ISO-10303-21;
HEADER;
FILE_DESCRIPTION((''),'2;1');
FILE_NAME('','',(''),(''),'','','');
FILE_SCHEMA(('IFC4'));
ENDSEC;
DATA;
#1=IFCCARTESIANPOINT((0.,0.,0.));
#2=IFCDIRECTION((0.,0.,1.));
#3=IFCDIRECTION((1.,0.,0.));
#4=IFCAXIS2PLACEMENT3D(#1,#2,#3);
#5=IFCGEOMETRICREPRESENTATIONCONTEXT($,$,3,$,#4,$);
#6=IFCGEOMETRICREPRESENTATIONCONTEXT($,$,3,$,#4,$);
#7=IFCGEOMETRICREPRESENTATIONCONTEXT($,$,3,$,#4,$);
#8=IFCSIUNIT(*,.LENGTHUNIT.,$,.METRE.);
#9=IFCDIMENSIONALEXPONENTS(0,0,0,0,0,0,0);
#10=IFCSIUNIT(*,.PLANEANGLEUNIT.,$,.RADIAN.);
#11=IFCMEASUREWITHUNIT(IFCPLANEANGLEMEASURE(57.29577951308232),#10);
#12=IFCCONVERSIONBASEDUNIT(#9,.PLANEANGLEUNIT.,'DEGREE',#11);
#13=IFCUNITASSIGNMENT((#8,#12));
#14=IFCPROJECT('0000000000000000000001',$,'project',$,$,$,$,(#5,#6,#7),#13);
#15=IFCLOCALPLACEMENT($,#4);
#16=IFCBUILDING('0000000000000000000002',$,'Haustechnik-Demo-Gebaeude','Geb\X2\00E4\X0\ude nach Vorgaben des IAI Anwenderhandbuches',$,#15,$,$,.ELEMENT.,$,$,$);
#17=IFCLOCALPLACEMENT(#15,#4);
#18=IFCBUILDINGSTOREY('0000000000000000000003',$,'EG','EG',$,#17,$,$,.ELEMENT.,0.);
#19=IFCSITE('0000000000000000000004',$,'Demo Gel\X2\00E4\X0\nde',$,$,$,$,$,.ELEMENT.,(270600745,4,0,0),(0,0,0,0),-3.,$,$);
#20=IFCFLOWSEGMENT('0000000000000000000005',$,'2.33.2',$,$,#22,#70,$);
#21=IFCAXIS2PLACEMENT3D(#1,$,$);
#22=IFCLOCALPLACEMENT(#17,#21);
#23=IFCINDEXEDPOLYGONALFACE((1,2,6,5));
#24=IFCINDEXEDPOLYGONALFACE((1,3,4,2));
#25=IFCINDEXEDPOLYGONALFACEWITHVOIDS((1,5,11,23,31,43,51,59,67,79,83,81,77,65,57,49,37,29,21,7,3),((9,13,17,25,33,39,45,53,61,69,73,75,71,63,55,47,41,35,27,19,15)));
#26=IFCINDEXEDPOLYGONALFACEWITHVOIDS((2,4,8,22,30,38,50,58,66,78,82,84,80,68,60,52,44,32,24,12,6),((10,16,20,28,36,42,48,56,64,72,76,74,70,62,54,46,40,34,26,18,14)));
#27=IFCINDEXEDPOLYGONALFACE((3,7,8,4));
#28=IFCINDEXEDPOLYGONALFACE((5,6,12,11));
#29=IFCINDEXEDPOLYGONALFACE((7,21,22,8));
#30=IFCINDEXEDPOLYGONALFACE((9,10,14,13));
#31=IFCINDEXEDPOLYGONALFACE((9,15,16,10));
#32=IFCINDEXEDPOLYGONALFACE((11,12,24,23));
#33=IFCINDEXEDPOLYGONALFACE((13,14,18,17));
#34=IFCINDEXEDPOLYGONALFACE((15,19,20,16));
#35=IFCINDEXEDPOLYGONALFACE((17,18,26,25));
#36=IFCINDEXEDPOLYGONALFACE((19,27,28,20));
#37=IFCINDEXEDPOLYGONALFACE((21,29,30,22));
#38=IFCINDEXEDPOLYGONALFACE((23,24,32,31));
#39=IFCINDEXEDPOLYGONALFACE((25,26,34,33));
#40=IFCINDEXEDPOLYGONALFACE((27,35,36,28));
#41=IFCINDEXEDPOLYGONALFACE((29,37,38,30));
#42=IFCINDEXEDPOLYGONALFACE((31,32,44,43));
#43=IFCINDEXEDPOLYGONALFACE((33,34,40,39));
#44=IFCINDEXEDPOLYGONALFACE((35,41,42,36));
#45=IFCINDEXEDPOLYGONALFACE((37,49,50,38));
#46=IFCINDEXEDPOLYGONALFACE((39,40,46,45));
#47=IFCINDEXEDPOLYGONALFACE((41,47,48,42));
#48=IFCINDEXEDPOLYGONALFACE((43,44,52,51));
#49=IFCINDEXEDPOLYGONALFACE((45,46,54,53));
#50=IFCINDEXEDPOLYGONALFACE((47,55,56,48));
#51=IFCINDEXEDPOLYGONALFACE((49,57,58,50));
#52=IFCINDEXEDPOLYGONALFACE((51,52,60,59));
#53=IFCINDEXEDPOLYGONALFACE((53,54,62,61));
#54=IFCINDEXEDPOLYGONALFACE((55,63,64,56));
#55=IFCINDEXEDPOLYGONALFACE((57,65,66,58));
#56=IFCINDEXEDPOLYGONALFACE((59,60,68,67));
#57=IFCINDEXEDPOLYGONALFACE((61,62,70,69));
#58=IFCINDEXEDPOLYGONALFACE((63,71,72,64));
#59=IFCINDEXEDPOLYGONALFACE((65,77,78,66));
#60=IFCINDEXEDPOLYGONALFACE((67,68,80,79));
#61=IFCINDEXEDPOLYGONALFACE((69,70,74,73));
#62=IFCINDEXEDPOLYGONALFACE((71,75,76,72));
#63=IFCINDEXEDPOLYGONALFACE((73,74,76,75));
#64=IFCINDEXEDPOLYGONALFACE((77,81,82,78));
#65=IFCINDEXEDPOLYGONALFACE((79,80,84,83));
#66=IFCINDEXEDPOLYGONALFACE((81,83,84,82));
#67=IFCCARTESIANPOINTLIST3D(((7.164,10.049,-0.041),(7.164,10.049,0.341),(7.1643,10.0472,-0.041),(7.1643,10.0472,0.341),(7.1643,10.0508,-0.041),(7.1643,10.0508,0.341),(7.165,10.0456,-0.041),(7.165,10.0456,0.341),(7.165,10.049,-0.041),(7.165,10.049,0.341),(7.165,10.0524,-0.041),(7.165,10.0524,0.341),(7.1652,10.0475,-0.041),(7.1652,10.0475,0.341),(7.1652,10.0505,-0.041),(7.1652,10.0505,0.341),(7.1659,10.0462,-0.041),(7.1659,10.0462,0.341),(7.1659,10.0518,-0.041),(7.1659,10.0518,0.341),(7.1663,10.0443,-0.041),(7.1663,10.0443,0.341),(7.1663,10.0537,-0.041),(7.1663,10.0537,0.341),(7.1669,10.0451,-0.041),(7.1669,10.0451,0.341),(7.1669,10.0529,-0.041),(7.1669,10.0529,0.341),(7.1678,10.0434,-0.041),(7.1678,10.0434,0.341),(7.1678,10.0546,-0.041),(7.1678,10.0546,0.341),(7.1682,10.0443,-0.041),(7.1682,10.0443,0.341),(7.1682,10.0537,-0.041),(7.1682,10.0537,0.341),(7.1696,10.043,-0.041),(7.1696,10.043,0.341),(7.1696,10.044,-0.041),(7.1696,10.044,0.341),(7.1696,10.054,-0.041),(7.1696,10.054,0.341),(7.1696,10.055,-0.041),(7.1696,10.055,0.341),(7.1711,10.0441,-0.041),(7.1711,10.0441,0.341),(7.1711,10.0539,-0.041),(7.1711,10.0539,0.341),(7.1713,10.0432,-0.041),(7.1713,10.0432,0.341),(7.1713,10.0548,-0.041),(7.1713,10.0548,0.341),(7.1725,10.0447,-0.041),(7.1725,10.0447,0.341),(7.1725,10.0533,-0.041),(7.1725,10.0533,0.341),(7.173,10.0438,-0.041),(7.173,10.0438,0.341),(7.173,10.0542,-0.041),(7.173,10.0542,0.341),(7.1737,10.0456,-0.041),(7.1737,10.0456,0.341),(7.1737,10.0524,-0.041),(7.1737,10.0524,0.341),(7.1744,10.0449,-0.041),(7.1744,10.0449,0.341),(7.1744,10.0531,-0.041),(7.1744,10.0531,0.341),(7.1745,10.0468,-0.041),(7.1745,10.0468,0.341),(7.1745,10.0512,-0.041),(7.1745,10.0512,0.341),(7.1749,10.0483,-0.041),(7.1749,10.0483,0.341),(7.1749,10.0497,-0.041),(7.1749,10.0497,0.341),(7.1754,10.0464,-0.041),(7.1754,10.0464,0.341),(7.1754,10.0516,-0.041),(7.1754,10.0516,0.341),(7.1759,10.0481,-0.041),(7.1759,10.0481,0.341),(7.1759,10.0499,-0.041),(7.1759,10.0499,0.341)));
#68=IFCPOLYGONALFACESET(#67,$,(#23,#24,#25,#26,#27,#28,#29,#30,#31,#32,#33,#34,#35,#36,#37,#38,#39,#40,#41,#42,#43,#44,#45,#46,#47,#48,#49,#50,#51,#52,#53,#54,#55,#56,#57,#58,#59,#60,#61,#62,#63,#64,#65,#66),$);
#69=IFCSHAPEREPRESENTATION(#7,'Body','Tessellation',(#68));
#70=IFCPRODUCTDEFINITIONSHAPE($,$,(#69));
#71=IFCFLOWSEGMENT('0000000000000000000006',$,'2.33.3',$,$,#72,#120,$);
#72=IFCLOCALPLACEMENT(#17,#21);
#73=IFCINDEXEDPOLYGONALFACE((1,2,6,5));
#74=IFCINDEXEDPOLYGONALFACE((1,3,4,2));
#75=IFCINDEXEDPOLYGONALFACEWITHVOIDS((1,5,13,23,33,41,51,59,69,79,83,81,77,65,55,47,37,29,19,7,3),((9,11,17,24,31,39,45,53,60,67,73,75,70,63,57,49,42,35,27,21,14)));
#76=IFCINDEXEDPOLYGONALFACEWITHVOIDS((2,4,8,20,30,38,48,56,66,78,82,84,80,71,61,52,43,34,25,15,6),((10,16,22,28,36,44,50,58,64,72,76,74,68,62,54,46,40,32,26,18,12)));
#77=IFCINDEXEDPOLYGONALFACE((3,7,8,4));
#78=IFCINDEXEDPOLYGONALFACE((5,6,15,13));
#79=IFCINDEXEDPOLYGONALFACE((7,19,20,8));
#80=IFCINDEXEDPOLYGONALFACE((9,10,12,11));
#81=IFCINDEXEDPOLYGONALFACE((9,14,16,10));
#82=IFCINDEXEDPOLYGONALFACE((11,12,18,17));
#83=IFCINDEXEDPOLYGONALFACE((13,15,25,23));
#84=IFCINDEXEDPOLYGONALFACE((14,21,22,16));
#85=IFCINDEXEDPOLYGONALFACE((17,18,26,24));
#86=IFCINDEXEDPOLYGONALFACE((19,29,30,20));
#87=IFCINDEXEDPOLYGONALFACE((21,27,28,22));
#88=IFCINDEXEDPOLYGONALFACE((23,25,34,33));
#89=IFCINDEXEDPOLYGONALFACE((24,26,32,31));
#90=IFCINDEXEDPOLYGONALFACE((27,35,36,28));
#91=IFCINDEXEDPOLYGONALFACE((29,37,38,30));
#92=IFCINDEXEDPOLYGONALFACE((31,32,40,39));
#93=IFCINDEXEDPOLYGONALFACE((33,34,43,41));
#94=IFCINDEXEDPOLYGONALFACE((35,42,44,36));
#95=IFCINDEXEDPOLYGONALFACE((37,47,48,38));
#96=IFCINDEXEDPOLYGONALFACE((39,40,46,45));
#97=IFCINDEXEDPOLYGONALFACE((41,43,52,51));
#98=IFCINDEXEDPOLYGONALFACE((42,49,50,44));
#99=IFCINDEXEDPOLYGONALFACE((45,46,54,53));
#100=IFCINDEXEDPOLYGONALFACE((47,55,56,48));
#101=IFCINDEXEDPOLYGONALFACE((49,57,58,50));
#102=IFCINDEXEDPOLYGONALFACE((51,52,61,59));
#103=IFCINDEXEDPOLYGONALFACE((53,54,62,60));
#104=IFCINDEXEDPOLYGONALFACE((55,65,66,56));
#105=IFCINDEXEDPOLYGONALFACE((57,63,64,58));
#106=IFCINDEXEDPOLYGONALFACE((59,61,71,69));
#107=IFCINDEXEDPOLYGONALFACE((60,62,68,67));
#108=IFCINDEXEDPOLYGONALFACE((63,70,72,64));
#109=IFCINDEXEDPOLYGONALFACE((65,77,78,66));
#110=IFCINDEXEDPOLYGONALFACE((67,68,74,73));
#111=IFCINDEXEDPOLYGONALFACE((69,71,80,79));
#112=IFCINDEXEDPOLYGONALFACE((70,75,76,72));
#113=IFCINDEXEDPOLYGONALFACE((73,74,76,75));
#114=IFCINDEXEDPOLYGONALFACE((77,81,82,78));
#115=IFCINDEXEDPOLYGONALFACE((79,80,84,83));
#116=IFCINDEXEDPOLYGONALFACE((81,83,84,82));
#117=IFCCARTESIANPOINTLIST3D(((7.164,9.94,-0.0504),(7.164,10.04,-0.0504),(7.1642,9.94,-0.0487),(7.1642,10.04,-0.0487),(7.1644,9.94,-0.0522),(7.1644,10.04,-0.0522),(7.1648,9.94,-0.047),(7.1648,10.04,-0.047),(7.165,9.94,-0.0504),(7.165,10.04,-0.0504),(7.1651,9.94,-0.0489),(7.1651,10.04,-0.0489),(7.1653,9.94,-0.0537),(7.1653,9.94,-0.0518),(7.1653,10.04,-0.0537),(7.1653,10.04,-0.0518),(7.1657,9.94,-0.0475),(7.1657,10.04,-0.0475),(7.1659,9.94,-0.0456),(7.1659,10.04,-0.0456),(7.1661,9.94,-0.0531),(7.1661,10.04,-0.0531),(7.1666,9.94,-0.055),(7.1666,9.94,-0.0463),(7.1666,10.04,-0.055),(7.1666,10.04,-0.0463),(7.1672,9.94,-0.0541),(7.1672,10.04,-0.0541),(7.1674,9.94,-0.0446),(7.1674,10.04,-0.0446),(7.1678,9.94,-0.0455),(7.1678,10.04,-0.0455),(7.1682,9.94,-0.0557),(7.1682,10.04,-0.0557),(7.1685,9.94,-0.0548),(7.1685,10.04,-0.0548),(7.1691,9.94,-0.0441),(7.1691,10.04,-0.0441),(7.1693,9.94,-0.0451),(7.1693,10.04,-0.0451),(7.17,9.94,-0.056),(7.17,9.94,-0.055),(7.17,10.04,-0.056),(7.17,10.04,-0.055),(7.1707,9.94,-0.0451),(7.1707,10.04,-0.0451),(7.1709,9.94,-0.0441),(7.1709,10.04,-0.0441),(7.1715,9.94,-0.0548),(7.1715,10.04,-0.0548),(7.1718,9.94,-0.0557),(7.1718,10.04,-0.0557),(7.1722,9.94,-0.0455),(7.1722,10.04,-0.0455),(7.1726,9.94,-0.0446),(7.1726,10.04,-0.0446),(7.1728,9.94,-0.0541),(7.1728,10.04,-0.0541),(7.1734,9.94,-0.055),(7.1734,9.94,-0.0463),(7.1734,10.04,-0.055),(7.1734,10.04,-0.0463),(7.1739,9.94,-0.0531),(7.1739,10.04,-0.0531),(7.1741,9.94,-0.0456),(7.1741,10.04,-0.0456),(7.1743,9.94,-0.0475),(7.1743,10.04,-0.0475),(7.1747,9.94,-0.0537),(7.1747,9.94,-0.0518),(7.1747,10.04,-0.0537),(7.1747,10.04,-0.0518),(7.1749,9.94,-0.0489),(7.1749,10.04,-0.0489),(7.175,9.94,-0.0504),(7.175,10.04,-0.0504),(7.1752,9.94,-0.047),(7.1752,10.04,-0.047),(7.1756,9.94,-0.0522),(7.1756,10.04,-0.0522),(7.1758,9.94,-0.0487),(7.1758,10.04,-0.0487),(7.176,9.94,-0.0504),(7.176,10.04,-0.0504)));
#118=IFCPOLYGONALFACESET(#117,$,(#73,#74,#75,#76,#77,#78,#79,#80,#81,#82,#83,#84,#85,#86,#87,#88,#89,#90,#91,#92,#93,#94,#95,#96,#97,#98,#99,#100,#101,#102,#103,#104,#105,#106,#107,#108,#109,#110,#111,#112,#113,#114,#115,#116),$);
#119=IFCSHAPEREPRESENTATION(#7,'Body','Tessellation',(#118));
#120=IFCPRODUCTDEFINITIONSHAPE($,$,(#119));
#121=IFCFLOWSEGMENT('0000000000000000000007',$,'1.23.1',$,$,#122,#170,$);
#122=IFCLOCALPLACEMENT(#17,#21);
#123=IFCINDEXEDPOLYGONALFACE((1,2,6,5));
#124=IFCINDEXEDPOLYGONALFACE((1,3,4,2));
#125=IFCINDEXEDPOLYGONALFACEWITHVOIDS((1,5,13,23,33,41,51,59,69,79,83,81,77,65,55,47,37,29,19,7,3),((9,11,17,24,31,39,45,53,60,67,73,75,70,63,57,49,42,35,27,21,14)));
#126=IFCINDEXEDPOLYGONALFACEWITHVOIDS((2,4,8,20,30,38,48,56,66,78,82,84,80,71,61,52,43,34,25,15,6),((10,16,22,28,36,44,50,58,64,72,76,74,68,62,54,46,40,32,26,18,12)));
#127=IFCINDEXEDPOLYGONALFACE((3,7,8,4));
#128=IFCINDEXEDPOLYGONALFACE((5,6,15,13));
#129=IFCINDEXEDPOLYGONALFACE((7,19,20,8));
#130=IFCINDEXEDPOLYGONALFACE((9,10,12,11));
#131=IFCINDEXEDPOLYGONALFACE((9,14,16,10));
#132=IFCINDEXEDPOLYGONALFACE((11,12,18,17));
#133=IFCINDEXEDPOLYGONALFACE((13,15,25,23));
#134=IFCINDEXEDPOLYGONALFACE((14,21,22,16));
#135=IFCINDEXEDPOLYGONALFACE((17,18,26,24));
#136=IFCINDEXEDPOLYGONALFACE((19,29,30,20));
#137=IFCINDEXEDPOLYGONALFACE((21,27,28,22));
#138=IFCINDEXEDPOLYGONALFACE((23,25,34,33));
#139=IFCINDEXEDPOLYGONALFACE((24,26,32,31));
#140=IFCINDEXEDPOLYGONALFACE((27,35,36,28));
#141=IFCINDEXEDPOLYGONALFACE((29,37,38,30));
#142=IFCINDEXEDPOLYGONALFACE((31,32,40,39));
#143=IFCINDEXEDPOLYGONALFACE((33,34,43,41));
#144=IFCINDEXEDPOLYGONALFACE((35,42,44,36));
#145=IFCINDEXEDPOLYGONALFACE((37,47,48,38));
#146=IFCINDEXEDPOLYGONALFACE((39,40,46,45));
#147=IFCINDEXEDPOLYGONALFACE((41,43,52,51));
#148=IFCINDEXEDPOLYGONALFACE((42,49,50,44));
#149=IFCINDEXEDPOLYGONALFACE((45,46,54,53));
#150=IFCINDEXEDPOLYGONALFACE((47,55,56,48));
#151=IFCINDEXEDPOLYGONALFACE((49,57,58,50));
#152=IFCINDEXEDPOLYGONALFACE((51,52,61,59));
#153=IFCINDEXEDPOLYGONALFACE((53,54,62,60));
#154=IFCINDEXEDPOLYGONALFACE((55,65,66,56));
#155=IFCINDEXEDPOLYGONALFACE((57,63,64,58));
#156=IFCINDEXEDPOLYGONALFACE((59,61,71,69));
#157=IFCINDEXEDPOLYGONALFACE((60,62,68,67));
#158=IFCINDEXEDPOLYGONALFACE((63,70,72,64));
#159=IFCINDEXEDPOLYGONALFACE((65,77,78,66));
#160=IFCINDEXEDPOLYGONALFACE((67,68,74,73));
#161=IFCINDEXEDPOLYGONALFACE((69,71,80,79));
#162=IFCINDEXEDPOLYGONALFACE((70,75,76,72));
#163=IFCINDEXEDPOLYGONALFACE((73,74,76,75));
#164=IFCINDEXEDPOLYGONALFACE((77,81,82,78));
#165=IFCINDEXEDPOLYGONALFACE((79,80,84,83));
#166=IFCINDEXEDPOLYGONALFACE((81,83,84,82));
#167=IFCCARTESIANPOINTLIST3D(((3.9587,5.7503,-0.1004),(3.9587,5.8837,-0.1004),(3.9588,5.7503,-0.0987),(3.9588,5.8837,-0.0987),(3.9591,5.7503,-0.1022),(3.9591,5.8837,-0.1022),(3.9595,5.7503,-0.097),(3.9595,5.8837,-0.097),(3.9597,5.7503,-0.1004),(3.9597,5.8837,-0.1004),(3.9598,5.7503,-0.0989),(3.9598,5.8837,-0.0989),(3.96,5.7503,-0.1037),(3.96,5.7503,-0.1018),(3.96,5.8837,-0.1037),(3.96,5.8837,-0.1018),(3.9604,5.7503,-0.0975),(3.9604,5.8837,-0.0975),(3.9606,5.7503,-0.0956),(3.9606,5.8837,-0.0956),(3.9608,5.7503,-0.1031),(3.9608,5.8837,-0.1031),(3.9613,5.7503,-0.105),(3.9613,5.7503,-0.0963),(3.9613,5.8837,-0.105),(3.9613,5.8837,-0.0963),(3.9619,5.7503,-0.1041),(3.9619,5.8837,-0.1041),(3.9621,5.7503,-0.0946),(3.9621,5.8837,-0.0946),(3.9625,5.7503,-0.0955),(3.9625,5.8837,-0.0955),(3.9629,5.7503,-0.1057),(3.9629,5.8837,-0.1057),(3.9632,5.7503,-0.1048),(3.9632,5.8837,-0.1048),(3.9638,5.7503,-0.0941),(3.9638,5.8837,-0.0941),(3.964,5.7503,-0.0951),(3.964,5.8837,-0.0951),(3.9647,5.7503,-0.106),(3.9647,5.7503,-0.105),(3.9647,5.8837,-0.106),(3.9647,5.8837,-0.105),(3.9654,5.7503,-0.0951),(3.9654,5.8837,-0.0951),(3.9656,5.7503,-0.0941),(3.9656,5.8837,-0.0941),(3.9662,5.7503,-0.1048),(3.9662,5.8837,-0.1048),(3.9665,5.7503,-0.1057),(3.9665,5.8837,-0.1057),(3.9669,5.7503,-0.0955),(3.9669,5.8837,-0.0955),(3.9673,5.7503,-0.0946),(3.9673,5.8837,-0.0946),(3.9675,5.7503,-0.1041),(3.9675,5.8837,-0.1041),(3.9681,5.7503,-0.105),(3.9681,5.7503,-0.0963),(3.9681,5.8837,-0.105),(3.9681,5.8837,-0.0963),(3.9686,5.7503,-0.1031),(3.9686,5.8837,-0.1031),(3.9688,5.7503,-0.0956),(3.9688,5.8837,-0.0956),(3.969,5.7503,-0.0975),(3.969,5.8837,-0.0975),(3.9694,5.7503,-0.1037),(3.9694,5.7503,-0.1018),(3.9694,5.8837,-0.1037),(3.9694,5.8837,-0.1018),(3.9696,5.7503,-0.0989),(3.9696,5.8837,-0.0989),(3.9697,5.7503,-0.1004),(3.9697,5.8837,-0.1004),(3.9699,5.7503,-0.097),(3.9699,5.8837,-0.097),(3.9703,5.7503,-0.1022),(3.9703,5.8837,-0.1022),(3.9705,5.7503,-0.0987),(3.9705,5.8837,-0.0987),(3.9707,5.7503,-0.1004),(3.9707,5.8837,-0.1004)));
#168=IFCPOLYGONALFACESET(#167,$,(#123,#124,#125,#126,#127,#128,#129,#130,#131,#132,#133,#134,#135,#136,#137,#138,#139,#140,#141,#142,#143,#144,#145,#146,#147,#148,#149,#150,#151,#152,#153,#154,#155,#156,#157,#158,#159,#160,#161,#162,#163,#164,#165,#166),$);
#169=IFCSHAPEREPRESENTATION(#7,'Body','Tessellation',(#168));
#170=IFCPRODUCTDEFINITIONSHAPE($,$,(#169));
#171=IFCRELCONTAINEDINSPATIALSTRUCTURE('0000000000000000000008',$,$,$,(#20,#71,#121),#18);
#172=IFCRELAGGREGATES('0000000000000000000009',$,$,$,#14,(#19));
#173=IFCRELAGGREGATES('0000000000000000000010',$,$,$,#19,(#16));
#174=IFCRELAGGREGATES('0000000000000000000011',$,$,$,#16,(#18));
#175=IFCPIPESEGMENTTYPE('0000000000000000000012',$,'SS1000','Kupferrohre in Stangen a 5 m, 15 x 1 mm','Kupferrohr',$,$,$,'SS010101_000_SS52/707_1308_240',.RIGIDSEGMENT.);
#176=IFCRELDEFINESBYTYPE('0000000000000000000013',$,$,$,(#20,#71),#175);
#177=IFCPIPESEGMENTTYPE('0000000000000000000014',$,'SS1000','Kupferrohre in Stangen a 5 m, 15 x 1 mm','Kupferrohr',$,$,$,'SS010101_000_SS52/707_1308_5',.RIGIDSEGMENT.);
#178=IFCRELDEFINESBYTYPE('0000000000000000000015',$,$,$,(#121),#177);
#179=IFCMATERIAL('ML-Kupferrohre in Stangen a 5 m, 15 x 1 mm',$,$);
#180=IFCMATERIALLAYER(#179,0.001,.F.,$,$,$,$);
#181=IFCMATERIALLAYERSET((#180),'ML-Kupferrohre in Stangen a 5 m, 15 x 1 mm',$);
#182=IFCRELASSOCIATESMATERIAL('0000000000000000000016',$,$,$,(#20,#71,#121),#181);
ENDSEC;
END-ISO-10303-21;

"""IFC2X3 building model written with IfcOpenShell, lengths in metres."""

from ifc_helpers import new_model, entity, si_unit, converted_unit, frame, origin_with_axes, origin_2d_with_axis, place, context, project, spatial, hollow_circle, extrude, material, layer, layer_set, layer_usage, type_object, element, save


model = new_model("IFC2X3")

# Units and contexts
context_of_model_1 = context(None, 3, world=origin_with_axes())
context_of_model_2 = context(None, 3, world=origin_with_axes())
context_of_model_3 = context(None, 3, world=origin_with_axes())
ifc_project = project(units=[si_unit("LENGTHUNIT", "METRE"), converted_unit("PLANEANGLEUNIT", "DEGREE", entity("IfcPlaneAngleMeasure", 57.29577951308232), si_unit("PLANEANGLEUNIT", "RADIAN"), dimensions=[0, 0, 0, 0, 0, 0, 0])], contexts=[context_of_model_1, context_of_model_2, context_of_model_3])

# Site, building, storey
site = spatial("IfcSite", under=ifc_project, Name="Demo Gelände", CompositionType="ELEMENT", RefLatitude=(270600745, 4, 0, 0), RefLongitude=(0, 0, 0, 0), RefElevation=-3.0)
building_placement = place(None, origin_with_axes())
building = spatial("IfcBuilding", under=site, at=building_placement, Name="Haustechnik-Demo-Gebaeude", Description="Gebäude nach Vorgaben des IAI Anwenderhandbuches", CompositionType="ELEMENT")
storey_placement = place(building_placement, origin_with_axes())
storey = spatial("IfcBuildingStorey", under=building, at=storey_placement, Name="EG", Description="EG", CompositionType="ELEMENT", Elevation=0.0)

# Flow segments
ifc_material_1 = material(Name="ML-Kupferrohre in Stangen a 5 m, 15 x 1 mm")
ifc_layer_1 = layer(ifc_material_1, 0.001, ventilated=False)
ifc_layer_set_1 = layer_set([ifc_layer_1], Name="ML-Kupferrohre in Stangen a 5 m, 15 x 1 mm")
ifc_layer_usage_1 = layer_usage(ifc_layer_set_1, "AXIS2", "POSITIVE", 0.0)
pipe_segment_type_1 = type_object("IfcPipeSegmentType", Name="SS1000", Description="Kupferrohre in Stangen a 5 m, 15 x 1 mm", ApplicableOccurrence="Kupferrohr", ElementType="SS010101_000_SS52/707_1308_240", PredefinedType="RIGIDSEGMENT")
flow_segment_1_placement = place(storey_placement, frame((7.17, 10.049, 0.341), z_axis=(0.0, 0.0, -1.0), x_axis=(-1.0, 0.0, 0.0)))
element("IfcFlowSegment", 1, at=flow_segment_1_placement, inside=storey, type_object=pipe_segment_type_1, material=ifc_layer_usage_1, Name="2.33.2", context=context_of_model_3, shape_type="SweptSolid", body=[
    extrude(hollow_circle(Radius=0.006, WallThickness=0.001, at=origin_2d_with_axis()), origin_with_axes(), (0.0, 0.0, 1.0), 0.382),
])
flow_segment_2_placement = place(storey_placement, frame((7.17, 10.04, -0.05), z_axis=(0.000001, -1.0, 0.0), x_axis=(0.0, 0.0, -1.0)))
element("IfcFlowSegment", 2, at=flow_segment_2_placement, inside=storey, type_object=pipe_segment_type_1, material=ifc_layer_usage_1, Name="2.33.3", context=context_of_model_3, shape_type="SweptSolid", body=[
    extrude(hollow_circle(Radius=0.006, WallThickness=0.001, at=origin_2d_with_axis()), origin_with_axes(), (0.0, 0.0, 1.0), 0.1),
])
pipe_segment_type_2 = type_object("IfcPipeSegmentType", Name="SS1000", Description="Kupferrohre in Stangen a 5 m, 15 x 1 mm", ApplicableOccurrence="Kupferrohr", ElementType="SS010101_000_SS52/707_1308_5", PredefinedType="RIGIDSEGMENT")
flow_segment_3_placement = place(storey_placement, frame((3.9647, 5.8837, -0.1), z_axis=(0.0, -1.0, 0.0), x_axis=(0.0, 0.0, -1.0)))
element("IfcFlowSegment", 3, at=flow_segment_3_placement, inside=storey, type_object=pipe_segment_type_2, material=ifc_layer_usage_1, Name="1.23.1", context=context_of_model_3, shape_type="SweptSolid", body=[
    extrude(hollow_circle(Radius=0.006, WallThickness=0.001, at=origin_2d_with_axis()), origin_with_axes(), (0.0, 0.0, 1.0), 0.1335),
])

save(model, "model.ifc")
